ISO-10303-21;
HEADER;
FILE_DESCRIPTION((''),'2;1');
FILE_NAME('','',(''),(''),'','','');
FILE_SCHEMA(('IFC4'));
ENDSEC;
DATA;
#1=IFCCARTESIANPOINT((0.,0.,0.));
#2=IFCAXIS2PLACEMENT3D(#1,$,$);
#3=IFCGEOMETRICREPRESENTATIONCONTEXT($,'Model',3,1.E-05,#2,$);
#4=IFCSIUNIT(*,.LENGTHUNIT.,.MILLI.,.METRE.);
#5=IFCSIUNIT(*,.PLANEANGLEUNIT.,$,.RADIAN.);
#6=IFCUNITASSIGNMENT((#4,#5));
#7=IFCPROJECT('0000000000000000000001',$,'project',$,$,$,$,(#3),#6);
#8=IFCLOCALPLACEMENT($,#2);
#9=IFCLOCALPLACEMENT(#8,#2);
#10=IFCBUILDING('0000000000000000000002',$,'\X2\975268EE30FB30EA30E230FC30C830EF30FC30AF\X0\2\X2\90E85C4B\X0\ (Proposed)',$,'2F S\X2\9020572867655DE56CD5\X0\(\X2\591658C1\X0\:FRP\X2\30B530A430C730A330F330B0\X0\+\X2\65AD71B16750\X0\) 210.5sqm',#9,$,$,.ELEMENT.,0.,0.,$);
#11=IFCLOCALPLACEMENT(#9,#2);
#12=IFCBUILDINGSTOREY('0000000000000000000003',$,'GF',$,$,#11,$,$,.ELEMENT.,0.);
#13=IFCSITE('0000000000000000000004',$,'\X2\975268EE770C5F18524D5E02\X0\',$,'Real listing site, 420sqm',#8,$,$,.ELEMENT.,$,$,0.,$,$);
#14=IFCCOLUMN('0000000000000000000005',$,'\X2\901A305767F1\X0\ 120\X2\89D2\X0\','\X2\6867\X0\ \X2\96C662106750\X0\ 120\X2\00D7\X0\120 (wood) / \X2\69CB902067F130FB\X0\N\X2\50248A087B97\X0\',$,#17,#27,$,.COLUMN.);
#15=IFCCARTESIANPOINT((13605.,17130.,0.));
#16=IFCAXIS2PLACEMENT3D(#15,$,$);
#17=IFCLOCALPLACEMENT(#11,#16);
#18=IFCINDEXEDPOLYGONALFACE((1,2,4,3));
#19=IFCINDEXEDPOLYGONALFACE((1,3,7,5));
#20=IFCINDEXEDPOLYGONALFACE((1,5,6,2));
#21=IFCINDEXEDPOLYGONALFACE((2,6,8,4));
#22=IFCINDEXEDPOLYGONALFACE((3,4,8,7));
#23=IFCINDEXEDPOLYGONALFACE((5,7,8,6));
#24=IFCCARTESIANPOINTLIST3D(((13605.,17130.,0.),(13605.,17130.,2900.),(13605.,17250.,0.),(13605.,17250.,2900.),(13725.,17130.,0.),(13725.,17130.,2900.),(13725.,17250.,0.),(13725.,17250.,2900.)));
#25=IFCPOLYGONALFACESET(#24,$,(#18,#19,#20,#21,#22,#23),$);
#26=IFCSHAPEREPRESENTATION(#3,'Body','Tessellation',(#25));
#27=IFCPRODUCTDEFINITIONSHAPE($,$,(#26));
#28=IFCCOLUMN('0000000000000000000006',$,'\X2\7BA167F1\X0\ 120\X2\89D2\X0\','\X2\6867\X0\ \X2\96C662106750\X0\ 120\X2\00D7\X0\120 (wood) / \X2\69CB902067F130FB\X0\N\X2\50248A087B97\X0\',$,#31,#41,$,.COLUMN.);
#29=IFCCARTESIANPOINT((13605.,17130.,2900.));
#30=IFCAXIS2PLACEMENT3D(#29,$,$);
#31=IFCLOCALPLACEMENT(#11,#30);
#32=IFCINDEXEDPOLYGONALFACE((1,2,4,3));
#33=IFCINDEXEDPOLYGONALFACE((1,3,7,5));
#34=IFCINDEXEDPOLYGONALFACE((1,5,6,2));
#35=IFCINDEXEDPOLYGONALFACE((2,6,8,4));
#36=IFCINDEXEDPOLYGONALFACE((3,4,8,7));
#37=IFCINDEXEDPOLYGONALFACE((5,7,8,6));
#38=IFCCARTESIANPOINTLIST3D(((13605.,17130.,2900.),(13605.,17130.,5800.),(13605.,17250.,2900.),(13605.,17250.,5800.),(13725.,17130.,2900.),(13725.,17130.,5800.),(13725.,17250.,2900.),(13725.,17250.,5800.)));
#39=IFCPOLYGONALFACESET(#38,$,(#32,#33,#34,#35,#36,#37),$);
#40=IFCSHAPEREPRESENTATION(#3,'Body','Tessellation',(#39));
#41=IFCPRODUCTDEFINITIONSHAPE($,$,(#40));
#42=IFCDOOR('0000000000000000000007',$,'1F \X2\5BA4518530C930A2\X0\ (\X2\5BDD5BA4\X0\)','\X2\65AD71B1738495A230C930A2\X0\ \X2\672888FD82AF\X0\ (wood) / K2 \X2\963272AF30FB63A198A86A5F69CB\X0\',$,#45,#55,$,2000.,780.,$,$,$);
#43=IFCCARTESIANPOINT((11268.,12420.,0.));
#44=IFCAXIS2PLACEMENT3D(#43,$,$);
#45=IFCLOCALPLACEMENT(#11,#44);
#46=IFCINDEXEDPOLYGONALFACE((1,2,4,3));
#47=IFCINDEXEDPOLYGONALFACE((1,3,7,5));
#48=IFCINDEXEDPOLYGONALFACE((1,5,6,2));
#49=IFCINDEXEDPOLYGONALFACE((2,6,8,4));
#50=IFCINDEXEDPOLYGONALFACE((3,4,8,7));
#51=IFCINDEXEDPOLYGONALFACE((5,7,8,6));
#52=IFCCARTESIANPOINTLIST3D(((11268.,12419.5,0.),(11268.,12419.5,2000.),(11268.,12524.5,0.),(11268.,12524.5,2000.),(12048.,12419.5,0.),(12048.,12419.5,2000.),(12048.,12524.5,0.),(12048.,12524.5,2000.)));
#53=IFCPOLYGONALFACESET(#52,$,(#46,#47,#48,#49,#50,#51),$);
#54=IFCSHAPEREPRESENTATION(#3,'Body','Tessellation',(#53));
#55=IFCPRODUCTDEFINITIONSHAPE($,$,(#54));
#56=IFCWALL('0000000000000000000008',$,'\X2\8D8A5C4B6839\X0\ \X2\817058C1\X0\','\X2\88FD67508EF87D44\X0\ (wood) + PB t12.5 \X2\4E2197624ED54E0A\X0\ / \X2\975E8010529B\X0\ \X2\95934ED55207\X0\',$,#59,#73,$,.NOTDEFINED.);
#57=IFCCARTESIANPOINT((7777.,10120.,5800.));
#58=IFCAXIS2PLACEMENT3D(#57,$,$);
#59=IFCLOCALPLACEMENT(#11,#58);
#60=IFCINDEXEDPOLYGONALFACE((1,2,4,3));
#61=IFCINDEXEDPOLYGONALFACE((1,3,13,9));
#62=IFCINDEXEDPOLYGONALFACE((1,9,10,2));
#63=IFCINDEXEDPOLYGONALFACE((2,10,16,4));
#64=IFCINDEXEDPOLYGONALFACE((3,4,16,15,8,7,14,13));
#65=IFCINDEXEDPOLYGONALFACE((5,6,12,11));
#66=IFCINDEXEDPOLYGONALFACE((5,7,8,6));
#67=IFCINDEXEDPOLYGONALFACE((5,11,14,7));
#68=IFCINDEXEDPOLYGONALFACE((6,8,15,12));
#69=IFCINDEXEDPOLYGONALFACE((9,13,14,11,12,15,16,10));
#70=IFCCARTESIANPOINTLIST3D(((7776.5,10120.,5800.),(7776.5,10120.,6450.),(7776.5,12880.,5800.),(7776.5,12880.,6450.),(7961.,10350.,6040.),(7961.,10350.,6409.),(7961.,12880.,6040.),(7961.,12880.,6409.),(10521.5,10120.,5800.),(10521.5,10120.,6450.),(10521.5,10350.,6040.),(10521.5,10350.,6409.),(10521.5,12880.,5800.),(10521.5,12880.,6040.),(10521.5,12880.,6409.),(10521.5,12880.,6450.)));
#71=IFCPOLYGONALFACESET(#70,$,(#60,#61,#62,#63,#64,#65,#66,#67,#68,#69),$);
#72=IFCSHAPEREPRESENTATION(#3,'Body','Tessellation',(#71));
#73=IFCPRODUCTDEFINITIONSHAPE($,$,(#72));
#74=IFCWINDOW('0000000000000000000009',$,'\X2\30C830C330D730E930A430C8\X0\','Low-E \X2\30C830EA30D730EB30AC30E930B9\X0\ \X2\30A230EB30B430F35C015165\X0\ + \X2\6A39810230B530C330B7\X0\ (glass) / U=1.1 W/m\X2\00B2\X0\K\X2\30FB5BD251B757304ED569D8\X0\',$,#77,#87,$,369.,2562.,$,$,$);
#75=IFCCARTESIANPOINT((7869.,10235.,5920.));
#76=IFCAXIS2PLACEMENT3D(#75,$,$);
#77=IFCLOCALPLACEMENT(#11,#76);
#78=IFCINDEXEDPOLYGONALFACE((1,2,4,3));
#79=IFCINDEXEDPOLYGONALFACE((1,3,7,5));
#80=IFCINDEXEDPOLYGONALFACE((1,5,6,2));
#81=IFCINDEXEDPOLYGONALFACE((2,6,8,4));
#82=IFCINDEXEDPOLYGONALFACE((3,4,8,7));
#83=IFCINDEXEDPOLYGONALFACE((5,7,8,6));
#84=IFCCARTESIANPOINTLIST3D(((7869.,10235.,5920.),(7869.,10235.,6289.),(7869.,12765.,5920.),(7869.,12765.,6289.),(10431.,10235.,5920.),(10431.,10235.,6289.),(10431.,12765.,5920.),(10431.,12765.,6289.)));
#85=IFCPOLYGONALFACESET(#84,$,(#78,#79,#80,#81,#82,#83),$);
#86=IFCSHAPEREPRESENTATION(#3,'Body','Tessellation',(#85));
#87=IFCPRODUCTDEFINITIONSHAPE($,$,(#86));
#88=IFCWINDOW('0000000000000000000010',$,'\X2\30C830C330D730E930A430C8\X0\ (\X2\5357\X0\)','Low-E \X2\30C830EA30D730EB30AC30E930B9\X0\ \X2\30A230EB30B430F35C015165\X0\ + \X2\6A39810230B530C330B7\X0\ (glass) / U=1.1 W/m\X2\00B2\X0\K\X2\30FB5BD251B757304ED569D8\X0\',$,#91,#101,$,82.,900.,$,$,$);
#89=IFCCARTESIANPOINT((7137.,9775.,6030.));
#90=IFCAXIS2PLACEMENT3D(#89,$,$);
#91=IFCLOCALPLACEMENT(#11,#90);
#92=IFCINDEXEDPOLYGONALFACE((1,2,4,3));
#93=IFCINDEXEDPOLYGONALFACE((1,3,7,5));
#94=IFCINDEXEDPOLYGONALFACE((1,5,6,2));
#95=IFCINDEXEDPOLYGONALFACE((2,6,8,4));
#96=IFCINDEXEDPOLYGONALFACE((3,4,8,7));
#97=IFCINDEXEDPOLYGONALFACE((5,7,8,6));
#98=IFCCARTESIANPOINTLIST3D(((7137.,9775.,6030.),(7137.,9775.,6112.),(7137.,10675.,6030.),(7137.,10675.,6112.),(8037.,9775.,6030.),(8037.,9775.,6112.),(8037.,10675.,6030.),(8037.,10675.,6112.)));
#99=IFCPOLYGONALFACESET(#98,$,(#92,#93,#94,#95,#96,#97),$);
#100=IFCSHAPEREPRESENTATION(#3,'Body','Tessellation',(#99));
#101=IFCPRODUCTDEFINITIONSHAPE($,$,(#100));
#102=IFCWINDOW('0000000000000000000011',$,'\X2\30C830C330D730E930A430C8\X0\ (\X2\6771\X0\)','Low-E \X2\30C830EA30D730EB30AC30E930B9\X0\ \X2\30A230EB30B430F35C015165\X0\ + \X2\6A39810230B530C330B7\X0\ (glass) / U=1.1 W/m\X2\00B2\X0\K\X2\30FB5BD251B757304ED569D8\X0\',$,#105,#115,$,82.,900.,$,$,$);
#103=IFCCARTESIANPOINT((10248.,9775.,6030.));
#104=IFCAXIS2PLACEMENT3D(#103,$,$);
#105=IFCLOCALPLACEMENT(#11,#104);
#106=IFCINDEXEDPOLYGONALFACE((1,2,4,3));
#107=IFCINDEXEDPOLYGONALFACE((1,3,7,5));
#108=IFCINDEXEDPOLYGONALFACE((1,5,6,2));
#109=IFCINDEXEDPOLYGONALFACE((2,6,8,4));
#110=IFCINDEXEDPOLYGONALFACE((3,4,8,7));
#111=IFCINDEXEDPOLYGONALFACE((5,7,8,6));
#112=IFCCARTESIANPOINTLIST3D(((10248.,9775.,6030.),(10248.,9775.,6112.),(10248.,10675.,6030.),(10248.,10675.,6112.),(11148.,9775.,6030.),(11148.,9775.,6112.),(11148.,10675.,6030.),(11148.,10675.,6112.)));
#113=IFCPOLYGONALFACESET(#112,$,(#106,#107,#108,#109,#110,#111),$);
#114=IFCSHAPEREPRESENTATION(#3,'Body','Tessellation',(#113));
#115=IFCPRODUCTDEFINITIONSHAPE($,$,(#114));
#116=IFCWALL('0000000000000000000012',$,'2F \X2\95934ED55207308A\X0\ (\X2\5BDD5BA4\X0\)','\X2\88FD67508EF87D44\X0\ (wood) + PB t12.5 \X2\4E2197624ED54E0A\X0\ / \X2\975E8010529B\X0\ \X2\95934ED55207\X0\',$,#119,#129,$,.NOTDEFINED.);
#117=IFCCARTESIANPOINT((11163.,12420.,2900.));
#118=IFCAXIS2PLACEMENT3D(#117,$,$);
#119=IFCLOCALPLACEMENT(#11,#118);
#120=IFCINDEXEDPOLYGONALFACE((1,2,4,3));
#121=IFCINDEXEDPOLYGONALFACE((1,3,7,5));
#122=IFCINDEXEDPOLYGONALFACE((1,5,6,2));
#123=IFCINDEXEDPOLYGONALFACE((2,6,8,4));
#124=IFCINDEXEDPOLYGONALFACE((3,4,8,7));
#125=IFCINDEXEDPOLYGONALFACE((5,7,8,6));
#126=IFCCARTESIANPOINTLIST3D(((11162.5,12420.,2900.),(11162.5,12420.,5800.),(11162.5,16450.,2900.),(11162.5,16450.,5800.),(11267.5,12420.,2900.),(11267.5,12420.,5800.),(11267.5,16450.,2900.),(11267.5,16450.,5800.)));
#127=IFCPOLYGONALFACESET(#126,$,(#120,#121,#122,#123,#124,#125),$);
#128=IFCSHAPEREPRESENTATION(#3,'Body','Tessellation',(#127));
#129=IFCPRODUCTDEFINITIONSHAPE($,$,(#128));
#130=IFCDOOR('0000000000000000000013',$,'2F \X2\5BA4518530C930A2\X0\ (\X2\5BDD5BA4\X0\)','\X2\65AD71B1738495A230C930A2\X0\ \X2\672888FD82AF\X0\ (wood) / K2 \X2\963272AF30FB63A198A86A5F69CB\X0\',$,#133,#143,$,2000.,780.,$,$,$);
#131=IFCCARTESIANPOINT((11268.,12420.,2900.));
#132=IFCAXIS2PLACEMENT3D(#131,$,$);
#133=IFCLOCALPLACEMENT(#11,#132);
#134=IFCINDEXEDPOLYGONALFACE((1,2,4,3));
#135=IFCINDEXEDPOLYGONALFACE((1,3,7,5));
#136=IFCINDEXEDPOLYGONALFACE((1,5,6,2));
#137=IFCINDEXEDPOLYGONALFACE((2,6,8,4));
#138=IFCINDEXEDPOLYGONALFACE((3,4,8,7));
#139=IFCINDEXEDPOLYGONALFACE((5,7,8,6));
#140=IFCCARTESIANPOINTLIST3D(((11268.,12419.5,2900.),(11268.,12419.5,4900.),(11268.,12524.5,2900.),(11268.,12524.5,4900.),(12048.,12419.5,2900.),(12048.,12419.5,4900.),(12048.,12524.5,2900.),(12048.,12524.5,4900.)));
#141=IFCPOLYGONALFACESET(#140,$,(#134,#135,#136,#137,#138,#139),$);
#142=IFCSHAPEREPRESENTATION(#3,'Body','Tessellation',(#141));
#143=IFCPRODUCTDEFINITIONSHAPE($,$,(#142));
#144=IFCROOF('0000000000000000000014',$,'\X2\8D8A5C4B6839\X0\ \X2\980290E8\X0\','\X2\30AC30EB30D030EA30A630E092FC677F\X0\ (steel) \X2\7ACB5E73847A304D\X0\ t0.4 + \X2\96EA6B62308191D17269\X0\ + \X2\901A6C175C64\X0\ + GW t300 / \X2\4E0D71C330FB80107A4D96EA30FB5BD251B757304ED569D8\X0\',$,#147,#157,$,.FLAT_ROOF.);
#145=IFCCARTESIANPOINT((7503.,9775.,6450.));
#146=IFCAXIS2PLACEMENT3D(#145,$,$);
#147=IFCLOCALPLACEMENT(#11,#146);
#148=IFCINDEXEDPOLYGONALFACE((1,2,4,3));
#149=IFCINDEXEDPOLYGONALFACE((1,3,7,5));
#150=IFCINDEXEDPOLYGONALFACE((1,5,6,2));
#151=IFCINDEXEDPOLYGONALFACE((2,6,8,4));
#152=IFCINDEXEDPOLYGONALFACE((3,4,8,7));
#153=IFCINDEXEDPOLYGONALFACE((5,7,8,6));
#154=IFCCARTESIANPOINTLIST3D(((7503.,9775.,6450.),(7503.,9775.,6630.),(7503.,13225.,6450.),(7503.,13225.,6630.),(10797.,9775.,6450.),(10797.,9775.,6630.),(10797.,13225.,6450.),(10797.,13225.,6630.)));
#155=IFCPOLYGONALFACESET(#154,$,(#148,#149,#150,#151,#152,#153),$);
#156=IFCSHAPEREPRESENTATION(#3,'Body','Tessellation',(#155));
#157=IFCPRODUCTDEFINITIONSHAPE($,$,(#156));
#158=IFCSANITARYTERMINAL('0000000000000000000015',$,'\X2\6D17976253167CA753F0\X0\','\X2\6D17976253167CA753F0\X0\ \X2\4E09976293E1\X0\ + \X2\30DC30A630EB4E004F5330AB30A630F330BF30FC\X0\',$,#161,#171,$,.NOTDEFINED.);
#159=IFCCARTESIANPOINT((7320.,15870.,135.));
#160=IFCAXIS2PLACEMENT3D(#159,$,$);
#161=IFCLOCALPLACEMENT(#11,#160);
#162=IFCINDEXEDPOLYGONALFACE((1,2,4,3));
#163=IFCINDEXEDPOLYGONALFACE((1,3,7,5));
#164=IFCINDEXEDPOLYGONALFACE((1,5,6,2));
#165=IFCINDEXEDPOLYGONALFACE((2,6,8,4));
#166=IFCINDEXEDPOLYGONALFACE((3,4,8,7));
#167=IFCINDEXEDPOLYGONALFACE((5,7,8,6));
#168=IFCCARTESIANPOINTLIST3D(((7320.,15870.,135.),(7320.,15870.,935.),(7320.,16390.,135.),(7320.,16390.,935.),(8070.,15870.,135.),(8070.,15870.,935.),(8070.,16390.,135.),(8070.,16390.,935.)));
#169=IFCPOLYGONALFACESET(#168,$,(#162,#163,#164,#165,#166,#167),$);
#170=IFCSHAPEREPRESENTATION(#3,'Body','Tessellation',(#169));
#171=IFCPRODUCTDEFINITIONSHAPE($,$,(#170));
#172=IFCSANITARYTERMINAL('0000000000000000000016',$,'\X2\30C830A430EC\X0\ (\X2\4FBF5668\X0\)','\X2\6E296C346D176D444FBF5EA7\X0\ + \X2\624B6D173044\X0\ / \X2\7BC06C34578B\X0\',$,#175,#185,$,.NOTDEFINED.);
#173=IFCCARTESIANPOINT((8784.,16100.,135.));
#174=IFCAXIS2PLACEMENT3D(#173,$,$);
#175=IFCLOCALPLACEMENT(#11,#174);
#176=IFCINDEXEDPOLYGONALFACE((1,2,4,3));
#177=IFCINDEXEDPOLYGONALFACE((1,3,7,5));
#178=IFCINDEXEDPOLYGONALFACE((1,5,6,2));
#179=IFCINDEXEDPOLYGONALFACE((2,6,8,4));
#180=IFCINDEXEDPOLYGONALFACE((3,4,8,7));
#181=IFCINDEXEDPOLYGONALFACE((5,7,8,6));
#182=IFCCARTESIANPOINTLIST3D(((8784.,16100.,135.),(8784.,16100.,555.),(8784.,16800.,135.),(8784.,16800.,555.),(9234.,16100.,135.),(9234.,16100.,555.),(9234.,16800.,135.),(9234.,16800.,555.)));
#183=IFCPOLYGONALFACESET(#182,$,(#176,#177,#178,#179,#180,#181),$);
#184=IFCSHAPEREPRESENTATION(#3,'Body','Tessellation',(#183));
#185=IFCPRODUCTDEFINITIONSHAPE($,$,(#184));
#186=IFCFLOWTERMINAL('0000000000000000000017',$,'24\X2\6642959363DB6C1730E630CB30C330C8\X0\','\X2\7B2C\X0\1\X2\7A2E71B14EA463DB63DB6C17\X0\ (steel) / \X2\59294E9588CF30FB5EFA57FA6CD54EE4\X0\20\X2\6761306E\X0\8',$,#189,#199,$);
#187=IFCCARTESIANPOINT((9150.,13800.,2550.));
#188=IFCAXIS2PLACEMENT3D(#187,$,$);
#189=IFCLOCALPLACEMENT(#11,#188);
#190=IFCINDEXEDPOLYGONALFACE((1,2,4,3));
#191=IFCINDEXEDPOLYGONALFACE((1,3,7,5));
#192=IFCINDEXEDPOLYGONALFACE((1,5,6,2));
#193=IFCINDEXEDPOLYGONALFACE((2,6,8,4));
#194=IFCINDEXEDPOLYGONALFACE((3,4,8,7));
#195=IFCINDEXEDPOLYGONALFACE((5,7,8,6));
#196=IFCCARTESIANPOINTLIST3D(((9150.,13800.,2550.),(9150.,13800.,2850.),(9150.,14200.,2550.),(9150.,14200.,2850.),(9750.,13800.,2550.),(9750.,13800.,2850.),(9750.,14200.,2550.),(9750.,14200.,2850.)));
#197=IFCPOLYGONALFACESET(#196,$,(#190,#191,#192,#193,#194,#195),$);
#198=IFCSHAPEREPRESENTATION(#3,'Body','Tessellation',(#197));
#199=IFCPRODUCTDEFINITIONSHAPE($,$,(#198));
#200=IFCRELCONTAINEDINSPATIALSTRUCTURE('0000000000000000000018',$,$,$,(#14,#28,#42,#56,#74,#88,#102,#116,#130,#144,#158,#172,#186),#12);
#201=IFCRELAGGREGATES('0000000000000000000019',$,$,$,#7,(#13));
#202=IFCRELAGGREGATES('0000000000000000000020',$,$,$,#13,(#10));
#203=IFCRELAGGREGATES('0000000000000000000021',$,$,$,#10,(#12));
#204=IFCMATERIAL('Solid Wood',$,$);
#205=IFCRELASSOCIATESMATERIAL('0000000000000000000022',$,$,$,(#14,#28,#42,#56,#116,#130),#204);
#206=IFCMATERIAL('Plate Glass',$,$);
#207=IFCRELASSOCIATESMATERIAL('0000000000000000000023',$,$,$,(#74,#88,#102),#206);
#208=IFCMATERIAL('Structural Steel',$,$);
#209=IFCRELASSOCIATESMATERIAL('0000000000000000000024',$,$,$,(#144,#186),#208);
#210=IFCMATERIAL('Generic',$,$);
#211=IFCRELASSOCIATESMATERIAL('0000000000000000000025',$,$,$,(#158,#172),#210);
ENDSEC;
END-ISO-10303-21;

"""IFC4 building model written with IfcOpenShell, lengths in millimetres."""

from ifc_helpers import new_model, si_unit, frame, frame_2d, origin, place, context, project, spatial, rectangle, extrude, material, element, fill, save


model = new_model("IFC4")

# Units and contexts
model_context = context("Model", 3, precision=1e-05, world=origin())
ifc_project = project(units=[si_unit("LENGTHUNIT", "METRE", prefix="MILLI"), si_unit("PLANEANGLEUNIT", "RADIAN")], contexts=[model_context])

# Site, building, storey
site_placement = place(None, origin())
site = spatial("IfcSite", under=ifc_project, at=site_placement, Name="青森県弘前市", ObjectType="Real listing site, 420sqm", CompositionType="ELEMENT", RefElevation=0.0)
building_placement = place(site_placement, origin())
building = spatial("IfcBuilding", under=site, at=building_placement, Name="青森・リモートワーク2部屋 (Proposed)", ObjectType="2F S造在来工法(外壁:FRPサイディング+断熱材) 210.5sqm", CompositionType="ELEMENT", ElevationOfRefHeight=0.0, ElevationOfTerrain=0.0)
storey_placement = place(building_placement, origin())
storey = spatial("IfcBuildingStorey", under=building, at=storey_placement, Name="GF", CompositionType="ELEMENT", Elevation=0.0)

# Columns
ifc_material_1 = material(Name="Solid Wood")
column_1_placement = place(storey_placement, frame((13605.0, 17130.0, 0.0)))
element("IfcColumn", 1, at=column_1_placement, inside=storey, material=ifc_material_1, Name="通し柱 120角", Description="桧 集成材 120×120 (wood) / 構造柱・N値計算", PredefinedType="COLUMN", context=model_context, shape_type="SweptSolid", body=[
    extrude(rectangle(XDim=120.0, YDim=120.0, at=frame_2d((60.0, 60.0))), frame((13605.0, 17130.0, 0.0)), (0.0, 0.0, 1.0), 2900.0),
])
column_2_placement = place(storey_placement, frame((13605.0, 17130.0, 2900.0)))
element("IfcColumn", 2, at=column_2_placement, inside=storey, material=ifc_material_1, Name="管柱 120角", Description="桧 集成材 120×120 (wood) / 構造柱・N値計算", PredefinedType="COLUMN", context=model_context, shape_type="SweptSolid", body=[
    extrude(rectangle(XDim=120.0, YDim=120.0, at=frame_2d((60.0, 60.0))), frame((13605.0, 17130.0, 2900.0)), (0.0, 0.0, 1.0), 2900.0),
])

# Door
door_1_placement = place(storey_placement, frame((11268.0, 12420.0, 0.0)))
element("IfcDoor", 3, at=door_1_placement, inside=storey, material=ifc_material_1, Name="1F 室内ドア (寝室)", Description="断熱玄関ドア 木製芯 (wood) / K2 防犯・採風機構", OverallHeight=2000.0, OverallWidth=780.0, context=model_context, shape_type="SweptSolid", body=[
    extrude(rectangle(XDim=780.0, YDim=105.0, at=frame_2d((390.0, 52.0))), frame((11268.0, 12420.0, 0.0)), (0.0, 0.0, 1.0), 2000.0),
])

# Wall, openings, windows
wall_1_placement = place(storey_placement, frame((7777.0, 10120.0, 5800.0)))
wall_1 = element("IfcWall", 4, at=wall_1_placement, inside=storey, material=ifc_material_1, Name="越屋根 腰壁", Description="製材軸組 (wood) + PB t12.5 両面仕上 / 非耐力 間仕切", PredefinedType="NOTDEFINED", context=model_context, shape_type="SweptSolid", body=[
    extrude(rectangle(XDim=2745.0, YDim=2760.0, at=frame_2d((1372.0, 1380.0))), frame((7777.0, 10120.0, 5800.0)), (0.0, 0.0, 1.0), 650.0),
])
opening_1_placement = place(storey_placement, frame((7869.0, 10235.0, 5920.0)))
opening_1 = element("IfcOpeningElement", 5, at=opening_1_placement, cuts=wall_1, PredefinedType="NOTDEFINED", context=model_context, shape_type="SweptSolid", body=[
    extrude(rectangle(XDim=2562.0, YDim=2530.0, at=frame_2d((1281.0, 1265.0))), frame((7869.0, 10235.0, 5920.0)), (0.0, 0.0, 1.0), 369.0),
])
opening_2_placement = place(storey_placement, frame((7137.0, 9775.0, 6030.0)))
opening_2 = element("IfcOpeningElement", 6, at=opening_2_placement, cuts=wall_1, PredefinedType="NOTDEFINED", context=model_context, shape_type="SweptSolid", body=[
    extrude(rectangle(XDim=900.0, YDim=900.0, at=frame_2d((450.0, 450.0))), frame((7137.0, 9775.0, 6030.0)), (0.0, 0.0, 1.0), 82.0),
])
opening_3_placement = place(storey_placement, frame((10248.0, 9775.0, 6030.0)))
opening_3 = element("IfcOpeningElement", 7, at=opening_3_placement, cuts=wall_1, PredefinedType="NOTDEFINED", context=model_context, shape_type="SweptSolid", body=[
    extrude(rectangle(XDim=900.0, YDim=900.0, at=frame_2d((450.0, 450.0))), frame((10248.0, 9775.0, 6030.0)), (0.0, 0.0, 1.0), 82.0),
])
ifc_material_2 = material(Name="Plate Glass")
window_1_placement = place(storey_placement, frame((7869.0, 10235.0, 5920.0)))
window_1 = element("IfcWindow", 8, at=window_1_placement, inside=storey, material=ifc_material_2, Name="トップライト", Description="Low-E トリプルガラス アルゴン封入 + 樹脂サッシ (glass) / U=1.1 W/m²K・寒冷地仕様", OverallHeight=369.0, OverallWidth=2562.0, context=model_context, shape_type="SweptSolid", body=[
    extrude(rectangle(XDim=2562.0, YDim=2530.0, at=frame_2d((1281.0, 1265.0))), frame((7869.0, 10235.0, 5920.0)), (0.0, 0.0, 1.0), 369.0),
])
fill(opening_1, window_1)
window_2_placement = place(storey_placement, frame((7137.0, 9775.0, 6030.0)))
window_2 = element("IfcWindow", 9, at=window_2_placement, inside=storey, material=ifc_material_2, Name="トップライト (南)", Description="Low-E トリプルガラス アルゴン封入 + 樹脂サッシ (glass) / U=1.1 W/m²K・寒冷地仕様", OverallHeight=82.0, OverallWidth=900.0, context=model_context, shape_type="SweptSolid", body=[
    extrude(rectangle(XDim=900.0, YDim=900.0, at=frame_2d((450.0, 450.0))), frame((7137.0, 9775.0, 6030.0)), (0.0, 0.0, 1.0), 82.0),
])
fill(opening_2, window_2)
window_3_placement = place(storey_placement, frame((10248.0, 9775.0, 6030.0)))
window_3 = element("IfcWindow", 10, at=window_3_placement, inside=storey, material=ifc_material_2, Name="トップライト (東)", Description="Low-E トリプルガラス アルゴン封入 + 樹脂サッシ (glass) / U=1.1 W/m²K・寒冷地仕様", OverallHeight=82.0, OverallWidth=900.0, context=model_context, shape_type="SweptSolid", body=[
    extrude(rectangle(XDim=900.0, YDim=900.0, at=frame_2d((450.0, 450.0))), frame((10248.0, 9775.0, 6030.0)), (0.0, 0.0, 1.0), 82.0),
])
fill(opening_3, window_3)

# Wall
wall_2_placement = place(storey_placement, frame((11163.0, 12420.0, 2900.0)))
element("IfcWall", 11, at=wall_2_placement, inside=storey, material=ifc_material_1, Name="2F 間仕切り (寝室)", Description="製材軸組 (wood) + PB t12.5 両面仕上 / 非耐力 間仕切", PredefinedType="NOTDEFINED", context=model_context, shape_type="SweptSolid", body=[
    extrude(rectangle(XDim=105.0, YDim=4030.0, at=frame_2d((52.0, 2015.0))), frame((11163.0, 12420.0, 2900.0)), (0.0, 0.0, 1.0), 2900.0),
])

# Door
door_2_placement = place(storey_placement, frame((11268.0, 12420.0, 2900.0)))
element("IfcDoor", 12, at=door_2_placement, inside=storey, material=ifc_material_1, Name="2F 室内ドア (寝室)", Description="断熱玄関ドア 木製芯 (wood) / K2 防犯・採風機構", OverallHeight=2000.0, OverallWidth=780.0, context=model_context, shape_type="SweptSolid", body=[
    extrude(rectangle(XDim=780.0, YDim=105.0, at=frame_2d((390.0, 52.0))), frame((11268.0, 12420.0, 2900.0)), (0.0, 0.0, 1.0), 2000.0),
])

# Roof
ifc_material_3 = material(Name="Structural Steel")
roof_placement = place(storey_placement, frame((7503.0, 9775.0, 6450.0)))
element("IfcRoof", 13, at=roof_placement, inside=storey, material=ifc_material_3, Name="越屋根 頂部", Description="ガルバリウム鋼板 (steel) 立平葺き t0.4 + 雪止め金物 + 通気層 + GW t300 / 不燃・耐積雪・寒冷地仕様", PredefinedType="FLAT_ROOF", context=model_context, shape_type="SweptSolid", body=[
    extrude(rectangle(XDim=3294.0, YDim=3450.0, at=frame_2d((1647.0, 1725.0))), frame((7503.0, 9775.0, 6450.0)), (0.0, 0.0, 1.0), 180.0),
])

# Sanitary terminals
ifc_material_4 = material(Name="Generic")
sanitary_terminal_1_placement = place(storey_placement, frame((7320.0, 15870.0, 135.0)))
element("IfcSanitaryTerminal", 14, at=sanitary_terminal_1_placement, inside=storey, material=ifc_material_4, Name="洗面化粧台", Description="洗面化粧台 三面鏡 + ボウル一体カウンター", PredefinedType="NOTDEFINED", context=model_context, shape_type="SweptSolid", body=[
    extrude(rectangle(XDim=750.0, YDim=520.0, at=frame_2d((375.0, 260.0))), frame((7320.0, 15870.0, 135.0)), (0.0, 0.0, 1.0), 800.0),
])
sanitary_terminal_2_placement = place(storey_placement, frame((8784.0, 16100.0, 135.0)))
element("IfcSanitaryTerminal", 15, at=sanitary_terminal_2_placement, inside=storey, material=ifc_material_4, Name="トイレ (便器)", Description="温水洗浄便座 + 手洗い / 節水型", PredefinedType="NOTDEFINED", context=model_context, shape_type="SweptSolid", body=[
    extrude(rectangle(XDim=450.0, YDim=700.0, at=frame_2d((225.0, 350.0))), frame((8784.0, 16100.0, 135.0)), (0.0, 0.0, 1.0), 420.0),
])

# Flow terminal
flow_terminal_placement = place(storey_placement, frame((9150.0, 13800.0, 2550.0)))
element("IfcFlowTerminal", 16, at=flow_terminal_placement, inside=storey, material=ifc_material_3, Name="24時間換気ユニット", Description="第1種熱交換換気 (steel) / 天井裏・建基法令20条の8", context=model_context, shape_type="SweptSolid", body=[
    extrude(rectangle(XDim=600.0, YDim=400.0, at=frame_2d((300.0, 200.0))), frame((9150.0, 13800.0, 2550.0)), (0.0, 0.0, 1.0), 300.0),
])

save(model, "model.ifc")
